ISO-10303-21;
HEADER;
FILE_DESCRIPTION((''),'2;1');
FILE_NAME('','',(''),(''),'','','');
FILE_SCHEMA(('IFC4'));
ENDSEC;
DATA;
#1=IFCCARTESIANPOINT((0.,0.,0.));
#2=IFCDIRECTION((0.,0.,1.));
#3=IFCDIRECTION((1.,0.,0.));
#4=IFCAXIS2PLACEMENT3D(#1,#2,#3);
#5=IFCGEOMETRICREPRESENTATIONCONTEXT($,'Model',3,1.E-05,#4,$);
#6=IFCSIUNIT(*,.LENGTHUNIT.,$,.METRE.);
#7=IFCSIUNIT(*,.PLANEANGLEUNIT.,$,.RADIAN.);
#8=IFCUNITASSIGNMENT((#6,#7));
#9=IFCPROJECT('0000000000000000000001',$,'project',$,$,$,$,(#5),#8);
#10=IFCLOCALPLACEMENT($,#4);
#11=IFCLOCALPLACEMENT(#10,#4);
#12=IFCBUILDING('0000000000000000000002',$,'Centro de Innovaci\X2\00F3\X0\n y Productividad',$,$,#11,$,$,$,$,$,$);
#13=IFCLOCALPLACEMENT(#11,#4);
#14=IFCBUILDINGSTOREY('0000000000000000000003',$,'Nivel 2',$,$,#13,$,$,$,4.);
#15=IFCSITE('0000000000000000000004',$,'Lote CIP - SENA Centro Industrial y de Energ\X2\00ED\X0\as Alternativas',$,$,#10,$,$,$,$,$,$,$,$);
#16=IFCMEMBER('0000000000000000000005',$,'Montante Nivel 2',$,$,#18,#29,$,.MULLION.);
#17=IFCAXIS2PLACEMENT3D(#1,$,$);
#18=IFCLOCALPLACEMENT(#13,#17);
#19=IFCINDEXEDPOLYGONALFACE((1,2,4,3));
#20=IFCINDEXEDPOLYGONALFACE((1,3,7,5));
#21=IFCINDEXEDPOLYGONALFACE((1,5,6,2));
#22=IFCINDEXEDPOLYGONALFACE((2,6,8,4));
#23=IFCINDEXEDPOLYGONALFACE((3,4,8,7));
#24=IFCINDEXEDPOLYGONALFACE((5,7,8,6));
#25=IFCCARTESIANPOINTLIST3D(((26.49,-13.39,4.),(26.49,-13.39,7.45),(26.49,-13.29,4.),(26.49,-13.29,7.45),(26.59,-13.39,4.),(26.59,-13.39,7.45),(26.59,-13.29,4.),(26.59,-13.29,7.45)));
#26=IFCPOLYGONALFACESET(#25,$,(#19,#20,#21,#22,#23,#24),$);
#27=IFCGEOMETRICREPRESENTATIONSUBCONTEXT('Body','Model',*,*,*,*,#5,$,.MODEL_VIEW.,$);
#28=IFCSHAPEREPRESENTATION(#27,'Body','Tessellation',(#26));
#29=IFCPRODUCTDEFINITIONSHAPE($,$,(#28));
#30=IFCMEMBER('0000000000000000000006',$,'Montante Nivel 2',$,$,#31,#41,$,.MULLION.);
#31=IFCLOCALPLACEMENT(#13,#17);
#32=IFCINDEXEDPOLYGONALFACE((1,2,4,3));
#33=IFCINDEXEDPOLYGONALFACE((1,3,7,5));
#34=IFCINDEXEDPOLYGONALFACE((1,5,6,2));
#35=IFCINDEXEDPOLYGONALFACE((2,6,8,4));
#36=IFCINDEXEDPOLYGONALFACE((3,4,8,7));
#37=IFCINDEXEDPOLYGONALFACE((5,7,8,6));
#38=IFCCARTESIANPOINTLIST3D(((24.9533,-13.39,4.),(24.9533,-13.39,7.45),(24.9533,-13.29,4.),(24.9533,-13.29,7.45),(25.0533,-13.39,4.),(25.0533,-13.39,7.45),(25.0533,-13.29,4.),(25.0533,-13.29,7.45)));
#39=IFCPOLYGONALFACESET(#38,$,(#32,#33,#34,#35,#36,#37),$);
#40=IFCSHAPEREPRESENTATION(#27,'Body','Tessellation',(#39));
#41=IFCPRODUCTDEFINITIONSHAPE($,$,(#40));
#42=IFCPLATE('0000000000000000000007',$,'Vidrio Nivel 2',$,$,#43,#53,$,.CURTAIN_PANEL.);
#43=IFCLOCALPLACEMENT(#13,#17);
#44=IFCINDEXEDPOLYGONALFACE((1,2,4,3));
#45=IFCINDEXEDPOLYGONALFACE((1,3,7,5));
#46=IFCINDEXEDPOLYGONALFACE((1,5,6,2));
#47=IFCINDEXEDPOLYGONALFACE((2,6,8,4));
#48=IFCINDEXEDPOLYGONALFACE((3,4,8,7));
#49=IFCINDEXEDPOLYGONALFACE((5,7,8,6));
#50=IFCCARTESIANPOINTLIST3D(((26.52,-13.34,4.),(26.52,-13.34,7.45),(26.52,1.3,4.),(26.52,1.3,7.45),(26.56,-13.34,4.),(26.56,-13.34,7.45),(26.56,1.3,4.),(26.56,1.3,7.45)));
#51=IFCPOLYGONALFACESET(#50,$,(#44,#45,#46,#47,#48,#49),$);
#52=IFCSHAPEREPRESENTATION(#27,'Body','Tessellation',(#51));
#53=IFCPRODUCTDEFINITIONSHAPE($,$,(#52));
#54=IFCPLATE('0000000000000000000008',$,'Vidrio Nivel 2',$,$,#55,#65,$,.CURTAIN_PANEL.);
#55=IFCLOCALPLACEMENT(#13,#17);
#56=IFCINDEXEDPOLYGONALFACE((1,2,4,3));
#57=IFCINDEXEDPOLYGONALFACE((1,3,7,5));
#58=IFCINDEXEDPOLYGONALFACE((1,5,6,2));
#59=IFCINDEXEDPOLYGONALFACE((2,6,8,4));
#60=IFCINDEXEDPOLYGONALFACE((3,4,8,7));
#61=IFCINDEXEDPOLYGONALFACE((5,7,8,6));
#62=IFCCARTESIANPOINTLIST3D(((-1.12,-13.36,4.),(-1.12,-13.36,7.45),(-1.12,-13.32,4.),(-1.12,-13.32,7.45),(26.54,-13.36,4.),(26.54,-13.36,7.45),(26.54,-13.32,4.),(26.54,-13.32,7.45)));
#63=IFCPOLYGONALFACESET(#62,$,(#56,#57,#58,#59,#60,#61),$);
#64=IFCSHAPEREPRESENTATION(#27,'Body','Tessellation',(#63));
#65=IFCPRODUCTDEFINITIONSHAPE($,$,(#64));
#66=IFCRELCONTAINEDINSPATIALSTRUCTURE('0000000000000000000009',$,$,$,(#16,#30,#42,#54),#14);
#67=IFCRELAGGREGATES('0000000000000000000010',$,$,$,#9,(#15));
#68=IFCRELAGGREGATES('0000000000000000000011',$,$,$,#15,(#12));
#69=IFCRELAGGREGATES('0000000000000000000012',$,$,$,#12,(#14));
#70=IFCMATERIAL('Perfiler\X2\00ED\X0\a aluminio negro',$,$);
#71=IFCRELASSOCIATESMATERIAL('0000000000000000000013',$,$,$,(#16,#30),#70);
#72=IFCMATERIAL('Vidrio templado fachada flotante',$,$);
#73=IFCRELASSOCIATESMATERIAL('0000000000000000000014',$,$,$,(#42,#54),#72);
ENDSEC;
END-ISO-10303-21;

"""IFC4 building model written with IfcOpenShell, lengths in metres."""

from ifc_helpers import new_model, si_unit, frame, origin_with_axes, place, context, subcontext, project, spatial, polyline, outline, extrude, material, element, save


model = new_model("IFC4")

# Units and contexts
model_context = context("Model", 3, precision=1e-05, world=origin_with_axes())
body_context = subcontext(model_context, "Body", "Model", "MODEL_VIEW")
ifc_project = project(units=[si_unit("LENGTHUNIT", "METRE"), si_unit("PLANEANGLEUNIT", "RADIAN")], contexts=[model_context])

# Site, building, storey
site_placement = place(None, origin_with_axes())
site = spatial("IfcSite", under=ifc_project, at=site_placement, Name="Lote CIP - SENA Centro Industrial y de Energías Alternativas")
building_placement = place(site_placement, origin_with_axes())
building = spatial("IfcBuilding", under=site, at=building_placement, Name="Centro de Innovación y Productividad")
storey_placement = place(building_placement, origin_with_axes())
storey = spatial("IfcBuildingStorey", under=building, at=storey_placement, Name="Nivel 2", Elevation=4.0)

# Members
ifc_material_1 = material(Name="Perfilería aluminio negro")
for number, where, z_axis, x_axis, name in (
    (1, (0.0, 0.0, 0.0), (0.0, 0.0, 1.0), (1.0, 0.0, 0.0), "Montante Nivel 2"),
):
    element("IfcMember", number, at=place(storey_placement, frame(where, z_axis=z_axis, x_axis=x_axis)), inside=storey, material=ifc_material_1, Name=name, PredefinedType="MULLION", context=body_context, shape_type="SweptSolid", body=[
        extrude(outline(polyline([(26.59, -13.29), (26.59, -13.39), (26.49, -13.39), (26.49, -13.29), (26.59, -13.29)])), frame((0.0, 0.0, 4.0)), (0.0, 0.0, 1.0), 3.45),
    ])
member_1_placement = place(storey_placement, origin_with_axes())
element("IfcMember", 2, at=member_1_placement, inside=storey, material=ifc_material_1, Name="Montante Nivel 2", PredefinedType="MULLION", context=body_context, shape_type="SweptSolid", body=[
    extrude(outline(polyline([(25.0533, -13.29), (25.0533, -13.39), (24.9533, -13.39), (24.9533, -13.29), (25.0533, -13.29)])), frame((0.0, 0.0, 4.0)), (0.0, 0.0, 1.0), 3.45),
])

# Plates
ifc_material_2 = material(Name="Vidrio templado fachada flotante")
plate_1_placement = place(storey_placement, origin_with_axes())
element("IfcPlate", 3, at=plate_1_placement, inside=storey, material=ifc_material_2, Name="Vidrio Nivel 2", PredefinedType="CURTAIN_PANEL", context=body_context, shape_type="SweptSolid", body=[
    extrude(outline(polyline([(26.52, -13.34), (26.52, 1.3), (26.56, 1.3), (26.56, -13.34), (26.52, -13.34)])), frame((0.0, 0.0, 4.0)), (0.0, 0.0, 1.0), 3.45),
])
plate_2_placement = place(storey_placement, origin_with_axes())
element("IfcPlate", 4, at=plate_2_placement, inside=storey, material=ifc_material_2, Name="Vidrio Nivel 2", PredefinedType="CURTAIN_PANEL", context=body_context, shape_type="SweptSolid", body=[
    extrude(outline(polyline([(-1.12, -13.32), (26.54, -13.32), (26.54, -13.36), (-1.12, -13.36), (-1.12, -13.32)])), frame((0.0, 0.0, 4.0)), (0.0, 0.0, 1.0), 3.45),
])

save(model, "model.ifc")
